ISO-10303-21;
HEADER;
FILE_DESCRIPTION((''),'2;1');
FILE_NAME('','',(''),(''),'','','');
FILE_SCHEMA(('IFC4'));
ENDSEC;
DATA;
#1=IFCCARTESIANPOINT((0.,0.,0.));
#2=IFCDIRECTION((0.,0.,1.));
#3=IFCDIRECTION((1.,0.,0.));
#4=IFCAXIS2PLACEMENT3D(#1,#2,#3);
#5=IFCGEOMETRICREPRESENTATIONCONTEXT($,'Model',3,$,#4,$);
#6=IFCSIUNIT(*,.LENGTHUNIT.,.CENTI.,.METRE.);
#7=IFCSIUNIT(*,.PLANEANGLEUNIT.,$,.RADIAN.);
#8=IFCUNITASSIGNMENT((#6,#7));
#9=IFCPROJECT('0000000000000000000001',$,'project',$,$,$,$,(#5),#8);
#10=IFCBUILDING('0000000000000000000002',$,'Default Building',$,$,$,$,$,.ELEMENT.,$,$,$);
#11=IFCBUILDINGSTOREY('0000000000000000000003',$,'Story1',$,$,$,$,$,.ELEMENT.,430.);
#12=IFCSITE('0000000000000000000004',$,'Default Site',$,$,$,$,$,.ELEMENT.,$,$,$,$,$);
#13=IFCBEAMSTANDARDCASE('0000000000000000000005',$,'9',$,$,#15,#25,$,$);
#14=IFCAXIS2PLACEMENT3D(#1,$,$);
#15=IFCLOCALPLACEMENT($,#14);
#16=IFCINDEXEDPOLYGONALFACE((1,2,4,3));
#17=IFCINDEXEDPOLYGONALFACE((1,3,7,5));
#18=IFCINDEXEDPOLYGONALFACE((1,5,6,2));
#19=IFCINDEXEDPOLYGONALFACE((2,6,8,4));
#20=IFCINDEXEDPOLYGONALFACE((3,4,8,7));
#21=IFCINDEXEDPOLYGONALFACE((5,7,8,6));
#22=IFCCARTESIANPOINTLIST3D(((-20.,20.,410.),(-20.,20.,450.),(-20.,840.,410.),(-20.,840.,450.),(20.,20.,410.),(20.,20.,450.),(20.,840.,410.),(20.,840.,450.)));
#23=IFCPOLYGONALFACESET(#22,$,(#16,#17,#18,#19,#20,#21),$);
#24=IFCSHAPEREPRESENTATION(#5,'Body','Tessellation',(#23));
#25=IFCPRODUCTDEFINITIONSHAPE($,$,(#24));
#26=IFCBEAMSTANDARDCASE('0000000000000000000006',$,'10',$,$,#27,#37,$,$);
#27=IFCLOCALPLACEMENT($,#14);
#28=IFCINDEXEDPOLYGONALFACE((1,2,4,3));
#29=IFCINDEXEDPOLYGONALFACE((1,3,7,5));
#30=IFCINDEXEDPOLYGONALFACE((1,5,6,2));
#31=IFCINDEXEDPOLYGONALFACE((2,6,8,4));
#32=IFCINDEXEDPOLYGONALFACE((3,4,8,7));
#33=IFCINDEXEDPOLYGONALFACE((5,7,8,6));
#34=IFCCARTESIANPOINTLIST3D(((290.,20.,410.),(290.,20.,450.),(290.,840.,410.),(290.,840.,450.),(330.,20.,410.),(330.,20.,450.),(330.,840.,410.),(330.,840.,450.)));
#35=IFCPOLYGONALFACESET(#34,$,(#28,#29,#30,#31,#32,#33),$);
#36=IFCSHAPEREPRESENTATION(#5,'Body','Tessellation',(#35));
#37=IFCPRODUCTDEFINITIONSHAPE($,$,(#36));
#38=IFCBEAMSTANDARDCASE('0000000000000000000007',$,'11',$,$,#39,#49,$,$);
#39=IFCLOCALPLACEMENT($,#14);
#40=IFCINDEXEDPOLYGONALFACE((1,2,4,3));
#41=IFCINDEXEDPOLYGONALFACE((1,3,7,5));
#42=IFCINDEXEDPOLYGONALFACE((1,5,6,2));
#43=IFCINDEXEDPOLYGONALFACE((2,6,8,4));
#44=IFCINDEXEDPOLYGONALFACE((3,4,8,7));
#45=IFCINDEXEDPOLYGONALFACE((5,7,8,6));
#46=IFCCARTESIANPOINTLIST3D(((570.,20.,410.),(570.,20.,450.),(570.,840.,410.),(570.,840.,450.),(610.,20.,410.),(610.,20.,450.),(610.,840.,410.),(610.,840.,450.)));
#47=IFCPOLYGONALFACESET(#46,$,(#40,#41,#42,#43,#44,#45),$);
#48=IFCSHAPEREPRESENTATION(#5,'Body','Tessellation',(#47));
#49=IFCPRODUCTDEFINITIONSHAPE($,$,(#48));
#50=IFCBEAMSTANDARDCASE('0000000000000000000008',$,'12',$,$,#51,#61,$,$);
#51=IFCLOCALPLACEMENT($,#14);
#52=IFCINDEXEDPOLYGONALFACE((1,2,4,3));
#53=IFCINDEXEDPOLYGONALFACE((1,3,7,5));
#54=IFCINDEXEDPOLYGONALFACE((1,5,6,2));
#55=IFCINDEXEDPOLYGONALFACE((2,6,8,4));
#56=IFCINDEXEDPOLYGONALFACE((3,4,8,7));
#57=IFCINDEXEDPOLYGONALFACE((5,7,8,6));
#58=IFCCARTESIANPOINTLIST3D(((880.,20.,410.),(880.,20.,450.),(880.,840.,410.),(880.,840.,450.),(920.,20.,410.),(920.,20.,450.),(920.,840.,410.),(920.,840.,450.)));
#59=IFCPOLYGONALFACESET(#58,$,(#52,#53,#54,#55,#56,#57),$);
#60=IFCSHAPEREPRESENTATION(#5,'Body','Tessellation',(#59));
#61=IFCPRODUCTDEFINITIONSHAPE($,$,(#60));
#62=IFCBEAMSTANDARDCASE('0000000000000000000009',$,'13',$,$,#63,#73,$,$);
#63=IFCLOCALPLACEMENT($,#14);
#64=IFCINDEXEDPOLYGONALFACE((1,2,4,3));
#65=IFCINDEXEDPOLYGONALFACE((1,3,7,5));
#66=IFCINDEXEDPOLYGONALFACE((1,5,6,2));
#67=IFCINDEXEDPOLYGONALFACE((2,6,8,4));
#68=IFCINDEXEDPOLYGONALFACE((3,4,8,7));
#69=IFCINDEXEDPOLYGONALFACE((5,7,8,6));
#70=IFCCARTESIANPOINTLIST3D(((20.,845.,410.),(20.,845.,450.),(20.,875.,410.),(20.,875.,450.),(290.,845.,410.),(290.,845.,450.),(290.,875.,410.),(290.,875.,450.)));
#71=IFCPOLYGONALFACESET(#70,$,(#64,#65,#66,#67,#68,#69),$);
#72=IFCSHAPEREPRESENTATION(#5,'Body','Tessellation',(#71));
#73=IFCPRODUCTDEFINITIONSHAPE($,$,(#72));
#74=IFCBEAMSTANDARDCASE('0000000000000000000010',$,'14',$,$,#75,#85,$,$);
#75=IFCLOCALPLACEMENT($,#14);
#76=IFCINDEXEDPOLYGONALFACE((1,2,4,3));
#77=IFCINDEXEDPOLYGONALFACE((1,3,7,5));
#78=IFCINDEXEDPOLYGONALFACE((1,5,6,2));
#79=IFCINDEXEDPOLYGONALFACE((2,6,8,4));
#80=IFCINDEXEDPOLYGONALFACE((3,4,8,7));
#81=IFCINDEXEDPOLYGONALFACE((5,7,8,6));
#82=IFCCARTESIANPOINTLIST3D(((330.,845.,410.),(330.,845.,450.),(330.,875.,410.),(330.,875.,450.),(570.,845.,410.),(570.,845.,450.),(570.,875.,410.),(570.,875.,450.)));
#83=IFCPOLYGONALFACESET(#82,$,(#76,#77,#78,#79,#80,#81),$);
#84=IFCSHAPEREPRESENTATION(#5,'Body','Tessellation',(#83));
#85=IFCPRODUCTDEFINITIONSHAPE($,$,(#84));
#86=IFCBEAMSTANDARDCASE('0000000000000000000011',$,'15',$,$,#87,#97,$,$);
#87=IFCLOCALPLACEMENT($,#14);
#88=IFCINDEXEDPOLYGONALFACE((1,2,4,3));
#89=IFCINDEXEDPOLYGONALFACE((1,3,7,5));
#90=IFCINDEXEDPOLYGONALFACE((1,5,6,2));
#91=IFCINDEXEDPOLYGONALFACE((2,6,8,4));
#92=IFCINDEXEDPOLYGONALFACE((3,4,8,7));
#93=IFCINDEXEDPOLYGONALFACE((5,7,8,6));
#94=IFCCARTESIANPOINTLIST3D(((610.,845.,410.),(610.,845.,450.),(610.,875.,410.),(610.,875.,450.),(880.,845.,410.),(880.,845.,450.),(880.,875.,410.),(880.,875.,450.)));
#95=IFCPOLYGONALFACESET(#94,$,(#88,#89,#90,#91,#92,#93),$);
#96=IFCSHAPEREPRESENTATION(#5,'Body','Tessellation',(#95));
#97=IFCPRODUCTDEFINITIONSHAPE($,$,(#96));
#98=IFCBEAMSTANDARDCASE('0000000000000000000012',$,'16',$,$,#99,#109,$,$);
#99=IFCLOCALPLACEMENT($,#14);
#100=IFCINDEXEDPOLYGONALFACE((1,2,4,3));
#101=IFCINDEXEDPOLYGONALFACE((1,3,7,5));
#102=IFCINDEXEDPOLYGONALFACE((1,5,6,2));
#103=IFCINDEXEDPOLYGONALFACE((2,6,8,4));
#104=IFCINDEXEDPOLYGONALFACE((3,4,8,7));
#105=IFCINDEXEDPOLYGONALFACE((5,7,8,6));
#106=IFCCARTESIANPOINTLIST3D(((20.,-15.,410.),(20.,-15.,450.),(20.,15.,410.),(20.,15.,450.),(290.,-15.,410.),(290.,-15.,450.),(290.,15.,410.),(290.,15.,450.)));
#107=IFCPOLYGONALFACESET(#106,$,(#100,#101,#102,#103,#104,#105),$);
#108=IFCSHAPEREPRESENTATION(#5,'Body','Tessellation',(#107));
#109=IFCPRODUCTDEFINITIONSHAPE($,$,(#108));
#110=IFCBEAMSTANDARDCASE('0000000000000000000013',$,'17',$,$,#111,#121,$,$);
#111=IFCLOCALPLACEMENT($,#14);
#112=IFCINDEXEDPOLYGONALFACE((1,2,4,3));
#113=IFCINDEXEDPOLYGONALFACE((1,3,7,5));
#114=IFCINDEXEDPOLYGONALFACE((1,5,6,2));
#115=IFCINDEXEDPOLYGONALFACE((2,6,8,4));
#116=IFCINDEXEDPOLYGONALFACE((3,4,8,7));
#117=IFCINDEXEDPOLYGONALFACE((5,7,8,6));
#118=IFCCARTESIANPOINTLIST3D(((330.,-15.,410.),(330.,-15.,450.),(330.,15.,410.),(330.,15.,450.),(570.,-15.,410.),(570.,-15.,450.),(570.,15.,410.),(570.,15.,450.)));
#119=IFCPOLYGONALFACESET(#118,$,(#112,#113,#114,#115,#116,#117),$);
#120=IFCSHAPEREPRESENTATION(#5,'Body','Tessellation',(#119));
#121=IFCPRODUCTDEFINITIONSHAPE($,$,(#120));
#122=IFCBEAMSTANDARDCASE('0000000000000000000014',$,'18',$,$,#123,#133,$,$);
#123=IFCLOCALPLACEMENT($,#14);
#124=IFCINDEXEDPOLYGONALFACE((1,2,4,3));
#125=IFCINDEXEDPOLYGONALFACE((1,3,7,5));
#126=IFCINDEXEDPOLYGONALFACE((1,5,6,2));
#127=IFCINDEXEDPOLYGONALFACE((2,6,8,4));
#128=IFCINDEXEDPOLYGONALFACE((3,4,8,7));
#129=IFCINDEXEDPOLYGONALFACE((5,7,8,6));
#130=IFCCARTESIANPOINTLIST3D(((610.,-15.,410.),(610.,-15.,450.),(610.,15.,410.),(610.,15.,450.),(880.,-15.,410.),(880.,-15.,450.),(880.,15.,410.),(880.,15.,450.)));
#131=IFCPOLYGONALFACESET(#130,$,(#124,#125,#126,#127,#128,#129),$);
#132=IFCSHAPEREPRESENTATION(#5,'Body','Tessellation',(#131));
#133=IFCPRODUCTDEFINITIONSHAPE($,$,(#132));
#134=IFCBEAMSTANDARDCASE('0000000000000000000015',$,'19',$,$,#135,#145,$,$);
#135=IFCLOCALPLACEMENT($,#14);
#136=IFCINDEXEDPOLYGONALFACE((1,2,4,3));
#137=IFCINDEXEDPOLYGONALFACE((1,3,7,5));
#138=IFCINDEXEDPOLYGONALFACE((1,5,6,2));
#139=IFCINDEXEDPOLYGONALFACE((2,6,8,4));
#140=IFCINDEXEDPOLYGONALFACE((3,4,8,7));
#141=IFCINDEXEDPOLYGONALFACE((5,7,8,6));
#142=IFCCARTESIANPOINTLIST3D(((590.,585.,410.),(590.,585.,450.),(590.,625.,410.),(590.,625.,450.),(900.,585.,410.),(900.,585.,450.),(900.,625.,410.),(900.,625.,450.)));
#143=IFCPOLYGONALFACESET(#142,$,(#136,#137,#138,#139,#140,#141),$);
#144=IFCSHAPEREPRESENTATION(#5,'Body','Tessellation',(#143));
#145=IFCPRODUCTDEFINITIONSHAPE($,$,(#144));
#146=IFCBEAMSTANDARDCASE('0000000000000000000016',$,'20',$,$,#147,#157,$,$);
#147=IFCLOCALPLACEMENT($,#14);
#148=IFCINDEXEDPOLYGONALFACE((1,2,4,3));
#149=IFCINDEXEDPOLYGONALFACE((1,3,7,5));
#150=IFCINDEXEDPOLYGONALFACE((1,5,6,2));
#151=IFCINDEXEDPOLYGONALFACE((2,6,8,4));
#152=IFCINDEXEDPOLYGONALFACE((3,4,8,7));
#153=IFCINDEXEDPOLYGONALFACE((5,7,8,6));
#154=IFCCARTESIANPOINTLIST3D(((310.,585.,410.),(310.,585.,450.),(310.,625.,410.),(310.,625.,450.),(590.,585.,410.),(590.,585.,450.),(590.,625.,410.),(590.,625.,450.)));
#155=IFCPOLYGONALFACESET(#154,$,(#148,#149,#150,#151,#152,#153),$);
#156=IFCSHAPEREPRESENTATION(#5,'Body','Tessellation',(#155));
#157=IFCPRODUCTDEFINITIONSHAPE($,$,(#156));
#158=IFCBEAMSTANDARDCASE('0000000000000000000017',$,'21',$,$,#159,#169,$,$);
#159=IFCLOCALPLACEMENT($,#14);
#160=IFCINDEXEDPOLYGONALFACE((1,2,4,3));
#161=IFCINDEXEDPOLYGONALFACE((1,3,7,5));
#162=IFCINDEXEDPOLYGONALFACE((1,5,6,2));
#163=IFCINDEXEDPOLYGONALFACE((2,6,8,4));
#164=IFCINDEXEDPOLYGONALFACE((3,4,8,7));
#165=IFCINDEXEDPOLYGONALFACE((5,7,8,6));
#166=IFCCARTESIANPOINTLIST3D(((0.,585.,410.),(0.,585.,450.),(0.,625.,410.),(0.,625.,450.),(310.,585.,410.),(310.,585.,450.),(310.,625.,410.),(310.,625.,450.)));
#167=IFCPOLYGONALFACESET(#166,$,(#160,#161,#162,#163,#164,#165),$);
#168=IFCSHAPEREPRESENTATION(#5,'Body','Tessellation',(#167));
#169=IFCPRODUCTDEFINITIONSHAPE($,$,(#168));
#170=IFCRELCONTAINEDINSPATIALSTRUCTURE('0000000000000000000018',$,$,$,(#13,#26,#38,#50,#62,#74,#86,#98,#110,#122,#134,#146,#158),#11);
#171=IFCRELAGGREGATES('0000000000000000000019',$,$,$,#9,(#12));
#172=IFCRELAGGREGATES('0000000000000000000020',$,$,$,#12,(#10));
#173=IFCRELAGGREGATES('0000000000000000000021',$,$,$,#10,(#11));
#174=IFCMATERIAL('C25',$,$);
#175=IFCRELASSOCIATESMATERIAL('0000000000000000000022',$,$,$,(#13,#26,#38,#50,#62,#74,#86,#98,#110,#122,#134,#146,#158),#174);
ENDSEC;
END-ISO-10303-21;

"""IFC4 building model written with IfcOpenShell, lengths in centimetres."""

from ifc_helpers import new_model, si_unit, frame, origin_with_axes, origin_2d_with_axis, place, context, project, spatial, rectangle, extrude, material, material_profile, profile_set, profile_usage, element, save


model = new_model("IFC4")

# Units and contexts
model_context = context("Model", 3, world=origin_with_axes())
ifc_project = project(units=[si_unit("LENGTHUNIT", "METRE", prefix="CENTI"), si_unit("PLANEANGLEUNIT", "RADIAN")], contexts=[model_context])

# Site, building, storey
site = spatial("IfcSite", under=ifc_project, Name="Default Site", CompositionType="ELEMENT")
building = spatial("IfcBuilding", under=site, Name="Default Building", CompositionType="ELEMENT")
storey = spatial("IfcBuildingStorey", under=building, Name="Story1", CompositionType="ELEMENT", Elevation=430.0)

# Beams
ifc_material = material(Name="C25")
ifc_material_profile_1 = material_profile(ifc_material, rectangle(XDim=40.0, YDim=40.0, at=origin_2d_with_axis()))
ifc_profile_set_1 = profile_set([ifc_material_profile_1])
ifc_profile_usage_1 = profile_usage(ifc_profile_set_1, cardinal=8)
beam_1_placement = place(None, frame((0.0, 20.0, 430.0), z_axis=(0.0, 1.0, 0.0), x_axis=(-1.0, 0.0, 0.0)))
element("IfcBeamStandardCase", 1, at=beam_1_placement, inside=storey, material=ifc_profile_usage_1, Name="9", context=model_context, shape_type="SweptSolid", body=[
    extrude(rectangle(XDim=40.0, YDim=40.0, at=origin_2d_with_axis()), origin_with_axes(), (0.0, 0.0, 1.0), 820.0),
])
ifc_material_profile_2 = material_profile(ifc_material, rectangle(XDim=40.0, YDim=40.0, at=origin_2d_with_axis()))
ifc_profile_set_2 = profile_set([ifc_material_profile_2])
ifc_profile_usage_2 = profile_usage(ifc_profile_set_2, cardinal=8)
beam_2_placement = place(None, frame((310.0, 20.0, 430.0), z_axis=(0.0, 1.0, 0.0), x_axis=(-1.0, 0.0, 0.0)))
element("IfcBeamStandardCase", 2, at=beam_2_placement, inside=storey, material=ifc_profile_usage_2, Name="10", context=model_context, shape_type="SweptSolid", body=[
    extrude(rectangle(XDim=40.0, YDim=40.0, at=origin_2d_with_axis()), origin_with_axes(), (0.0, 0.0, 1.0), 820.0),
])
ifc_material_profile_3 = material_profile(ifc_material, rectangle(XDim=40.0, YDim=40.0, at=origin_2d_with_axis()))
ifc_profile_set_3 = profile_set([ifc_material_profile_3])
ifc_profile_usage_3 = profile_usage(ifc_profile_set_3, cardinal=8)
beam_3_placement = place(None, frame((590.0, 20.0, 430.0), z_axis=(0.0, 1.0, 0.0), x_axis=(-1.0, 0.0, 0.0)))
element("IfcBeamStandardCase", 3, at=beam_3_placement, inside=storey, material=ifc_profile_usage_3, Name="11", context=model_context, shape_type="SweptSolid", body=[
    extrude(rectangle(XDim=40.0, YDim=40.0, at=origin_2d_with_axis()), origin_with_axes(), (0.0, 0.0, 1.0), 820.0),
])
ifc_material_profile_4 = material_profile(ifc_material, rectangle(XDim=40.0, YDim=40.0, at=origin_2d_with_axis()))
ifc_profile_set_4 = profile_set([ifc_material_profile_4])
ifc_profile_usage_4 = profile_usage(ifc_profile_set_4, cardinal=8)
beam_4_placement = place(None, frame((900.0, 20.0, 430.0), z_axis=(0.0, 1.0, 0.0), x_axis=(-1.0, 0.0, 0.0)))
element("IfcBeamStandardCase", 4, at=beam_4_placement, inside=storey, material=ifc_profile_usage_4, Name="12", context=model_context, shape_type="SweptSolid", body=[
    extrude(rectangle(XDim=40.0, YDim=40.0, at=origin_2d_with_axis()), origin_with_axes(), (0.0, 0.0, 1.0), 820.0),
])
ifc_material_profile_5 = material_profile(ifc_material, rectangle(XDim=30.0, YDim=40.0, at=origin_2d_with_axis()))
ifc_profile_set_5 = profile_set([ifc_material_profile_5])
ifc_profile_usage_5 = profile_usage(ifc_profile_set_5, cardinal=8)
beam_5_placement = place(None, frame((20.0, 860.0, 430.0), z_axis=(1.0, 0.0, 0.0), x_axis=(0.0, 1.0, 0.0)))
element("IfcBeamStandardCase", 5, at=beam_5_placement, inside=storey, material=ifc_profile_usage_5, Name="13", context=model_context, shape_type="SweptSolid", body=[
    extrude(rectangle(XDim=30.0, YDim=40.0, at=origin_2d_with_axis()), origin_with_axes(), (0.0, 0.0, 1.0), 270.0),
])
ifc_material_profile_6 = material_profile(ifc_material, rectangle(XDim=30.0, YDim=40.0, at=origin_2d_with_axis()))
ifc_profile_set_6 = profile_set([ifc_material_profile_6])
ifc_profile_usage_6 = profile_usage(ifc_profile_set_6, cardinal=8)
beam_6_placement = place(None, frame((330.0, 860.0, 430.0), z_axis=(1.0, 0.0, 0.0), x_axis=(0.0, 1.0, 0.0)))
element("IfcBeamStandardCase", 6, at=beam_6_placement, inside=storey, material=ifc_profile_usage_6, Name="14", context=model_context, shape_type="SweptSolid", body=[
    extrude(rectangle(XDim=30.0, YDim=40.0, at=origin_2d_with_axis()), origin_with_axes(), (0.0, 0.0, 1.0), 240.0),
])
ifc_material_profile_7 = material_profile(ifc_material, rectangle(XDim=30.0, YDim=40.0, at=origin_2d_with_axis()))
ifc_profile_set_7 = profile_set([ifc_material_profile_7])
ifc_profile_usage_7 = profile_usage(ifc_profile_set_7, cardinal=8)
beam_7_placement = place(None, frame((610.0, 860.0, 430.0), z_axis=(1.0, 0.0, 0.0), x_axis=(0.0, 1.0, 0.0)))
element("IfcBeamStandardCase", 7, at=beam_7_placement, inside=storey, material=ifc_profile_usage_7, Name="15", context=model_context, shape_type="SweptSolid", body=[
    extrude(rectangle(XDim=30.0, YDim=40.0, at=origin_2d_with_axis()), origin_with_axes(), (0.0, 0.0, 1.0), 270.0),
])
ifc_material_profile_8 = material_profile(ifc_material, rectangle(XDim=30.0, YDim=40.0, at=origin_2d_with_axis()))
ifc_profile_set_8 = profile_set([ifc_material_profile_8])
ifc_profile_usage_8 = profile_usage(ifc_profile_set_8, cardinal=8)
beam_8_placement = place(None, frame((20.0, 0.0, 430.0), z_axis=(1.0, 0.0, 0.0), x_axis=(0.0, 1.0, 0.0)))
element("IfcBeamStandardCase", 8, at=beam_8_placement, inside=storey, material=ifc_profile_usage_8, Name="16", context=model_context, shape_type="SweptSolid", body=[
    extrude(rectangle(XDim=30.0, YDim=40.0, at=origin_2d_with_axis()), origin_with_axes(), (0.0, 0.0, 1.0), 270.0),
])
ifc_material_profile_9 = material_profile(ifc_material, rectangle(XDim=30.0, YDim=40.0, at=origin_2d_with_axis()))
ifc_profile_set_9 = profile_set([ifc_material_profile_9])
ifc_profile_usage_9 = profile_usage(ifc_profile_set_9, cardinal=8)
beam_9_placement = place(None, frame((330.0, 0.0, 430.0), z_axis=(1.0, 0.0, 0.0), x_axis=(0.0, 1.0, 0.0)))
element("IfcBeamStandardCase", 9, at=beam_9_placement, inside=storey, material=ifc_profile_usage_9, Name="17", context=model_context, shape_type="SweptSolid", body=[
    extrude(rectangle(XDim=30.0, YDim=40.0, at=origin_2d_with_axis()), origin_with_axes(), (0.0, 0.0, 1.0), 240.0),
])
ifc_material_profile_10 = material_profile(ifc_material, rectangle(XDim=30.0, YDim=40.0, at=origin_2d_with_axis()))
ifc_profile_set_10 = profile_set([ifc_material_profile_10])
ifc_profile_usage_10 = profile_usage(ifc_profile_set_10, cardinal=8)
beam_10_placement = place(None, frame((610.0, 0.0, 430.0), z_axis=(1.0, 0.0, 0.0), x_axis=(0.0, 1.0, 0.0)))
element("IfcBeamStandardCase", 10, at=beam_10_placement, inside=storey, material=ifc_profile_usage_10, Name="18", context=model_context, shape_type="SweptSolid", body=[
    extrude(rectangle(XDim=30.0, YDim=40.0, at=origin_2d_with_axis()), origin_with_axes(), (0.0, 0.0, 1.0), 270.0),
])
ifc_material_profile_11 = material_profile(ifc_material, rectangle(XDim=40.0, YDim=40.0, at=origin_2d_with_axis()))
ifc_profile_set_11 = profile_set([ifc_material_profile_11])
ifc_profile_usage_11 = profile_usage(ifc_profile_set_11, cardinal=8)
beam_11_placement = place(None, frame((590.0, 605.0, 430.0), z_axis=(1.0, 0.0, 0.0), x_axis=(0.0, 1.0, 0.0)))
element("IfcBeamStandardCase", 11, at=beam_11_placement, inside=storey, material=ifc_profile_usage_11, Name="19", context=model_context, shape_type="SweptSolid", body=[
    extrude(rectangle(XDim=40.0, YDim=40.0, at=origin_2d_with_axis()), origin_with_axes(), (0.0, 0.0, 1.0), 310.0),
])
ifc_material_profile_12 = material_profile(ifc_material, rectangle(XDim=40.0, YDim=40.0, at=origin_2d_with_axis()))
ifc_profile_set_12 = profile_set([ifc_material_profile_12])
ifc_profile_usage_12 = profile_usage(ifc_profile_set_12, cardinal=8)
beam_12_placement = place(None, frame((310.0, 605.0, 430.0), z_axis=(1.0, 0.0, 0.0), x_axis=(0.0, 1.0, 0.0)))
element("IfcBeamStandardCase", 12, at=beam_12_placement, inside=storey, material=ifc_profile_usage_12, Name="20", context=model_context, shape_type="SweptSolid", body=[
    extrude(rectangle(XDim=40.0, YDim=40.0, at=origin_2d_with_axis()), origin_with_axes(), (0.0, 0.0, 1.0), 280.0),
])
ifc_material_profile_13 = material_profile(ifc_material, rectangle(XDim=40.0, YDim=40.0, at=origin_2d_with_axis()))
ifc_profile_set_13 = profile_set([ifc_material_profile_13])
ifc_profile_usage_13 = profile_usage(ifc_profile_set_13, cardinal=8)
beam_13_placement = place(None, frame((0.0, 605.0, 430.0), z_axis=(1.0, 0.0, 0.0), x_axis=(0.0, 1.0, 0.0)))
element("IfcBeamStandardCase", 13, at=beam_13_placement, inside=storey, material=ifc_profile_usage_13, Name="21", context=model_context, shape_type="SweptSolid", body=[
    extrude(rectangle(XDim=40.0, YDim=40.0, at=origin_2d_with_axis()), origin_with_axes(), (0.0, 0.0, 1.0), 310.0),
])

save(model, "model.ifc")
